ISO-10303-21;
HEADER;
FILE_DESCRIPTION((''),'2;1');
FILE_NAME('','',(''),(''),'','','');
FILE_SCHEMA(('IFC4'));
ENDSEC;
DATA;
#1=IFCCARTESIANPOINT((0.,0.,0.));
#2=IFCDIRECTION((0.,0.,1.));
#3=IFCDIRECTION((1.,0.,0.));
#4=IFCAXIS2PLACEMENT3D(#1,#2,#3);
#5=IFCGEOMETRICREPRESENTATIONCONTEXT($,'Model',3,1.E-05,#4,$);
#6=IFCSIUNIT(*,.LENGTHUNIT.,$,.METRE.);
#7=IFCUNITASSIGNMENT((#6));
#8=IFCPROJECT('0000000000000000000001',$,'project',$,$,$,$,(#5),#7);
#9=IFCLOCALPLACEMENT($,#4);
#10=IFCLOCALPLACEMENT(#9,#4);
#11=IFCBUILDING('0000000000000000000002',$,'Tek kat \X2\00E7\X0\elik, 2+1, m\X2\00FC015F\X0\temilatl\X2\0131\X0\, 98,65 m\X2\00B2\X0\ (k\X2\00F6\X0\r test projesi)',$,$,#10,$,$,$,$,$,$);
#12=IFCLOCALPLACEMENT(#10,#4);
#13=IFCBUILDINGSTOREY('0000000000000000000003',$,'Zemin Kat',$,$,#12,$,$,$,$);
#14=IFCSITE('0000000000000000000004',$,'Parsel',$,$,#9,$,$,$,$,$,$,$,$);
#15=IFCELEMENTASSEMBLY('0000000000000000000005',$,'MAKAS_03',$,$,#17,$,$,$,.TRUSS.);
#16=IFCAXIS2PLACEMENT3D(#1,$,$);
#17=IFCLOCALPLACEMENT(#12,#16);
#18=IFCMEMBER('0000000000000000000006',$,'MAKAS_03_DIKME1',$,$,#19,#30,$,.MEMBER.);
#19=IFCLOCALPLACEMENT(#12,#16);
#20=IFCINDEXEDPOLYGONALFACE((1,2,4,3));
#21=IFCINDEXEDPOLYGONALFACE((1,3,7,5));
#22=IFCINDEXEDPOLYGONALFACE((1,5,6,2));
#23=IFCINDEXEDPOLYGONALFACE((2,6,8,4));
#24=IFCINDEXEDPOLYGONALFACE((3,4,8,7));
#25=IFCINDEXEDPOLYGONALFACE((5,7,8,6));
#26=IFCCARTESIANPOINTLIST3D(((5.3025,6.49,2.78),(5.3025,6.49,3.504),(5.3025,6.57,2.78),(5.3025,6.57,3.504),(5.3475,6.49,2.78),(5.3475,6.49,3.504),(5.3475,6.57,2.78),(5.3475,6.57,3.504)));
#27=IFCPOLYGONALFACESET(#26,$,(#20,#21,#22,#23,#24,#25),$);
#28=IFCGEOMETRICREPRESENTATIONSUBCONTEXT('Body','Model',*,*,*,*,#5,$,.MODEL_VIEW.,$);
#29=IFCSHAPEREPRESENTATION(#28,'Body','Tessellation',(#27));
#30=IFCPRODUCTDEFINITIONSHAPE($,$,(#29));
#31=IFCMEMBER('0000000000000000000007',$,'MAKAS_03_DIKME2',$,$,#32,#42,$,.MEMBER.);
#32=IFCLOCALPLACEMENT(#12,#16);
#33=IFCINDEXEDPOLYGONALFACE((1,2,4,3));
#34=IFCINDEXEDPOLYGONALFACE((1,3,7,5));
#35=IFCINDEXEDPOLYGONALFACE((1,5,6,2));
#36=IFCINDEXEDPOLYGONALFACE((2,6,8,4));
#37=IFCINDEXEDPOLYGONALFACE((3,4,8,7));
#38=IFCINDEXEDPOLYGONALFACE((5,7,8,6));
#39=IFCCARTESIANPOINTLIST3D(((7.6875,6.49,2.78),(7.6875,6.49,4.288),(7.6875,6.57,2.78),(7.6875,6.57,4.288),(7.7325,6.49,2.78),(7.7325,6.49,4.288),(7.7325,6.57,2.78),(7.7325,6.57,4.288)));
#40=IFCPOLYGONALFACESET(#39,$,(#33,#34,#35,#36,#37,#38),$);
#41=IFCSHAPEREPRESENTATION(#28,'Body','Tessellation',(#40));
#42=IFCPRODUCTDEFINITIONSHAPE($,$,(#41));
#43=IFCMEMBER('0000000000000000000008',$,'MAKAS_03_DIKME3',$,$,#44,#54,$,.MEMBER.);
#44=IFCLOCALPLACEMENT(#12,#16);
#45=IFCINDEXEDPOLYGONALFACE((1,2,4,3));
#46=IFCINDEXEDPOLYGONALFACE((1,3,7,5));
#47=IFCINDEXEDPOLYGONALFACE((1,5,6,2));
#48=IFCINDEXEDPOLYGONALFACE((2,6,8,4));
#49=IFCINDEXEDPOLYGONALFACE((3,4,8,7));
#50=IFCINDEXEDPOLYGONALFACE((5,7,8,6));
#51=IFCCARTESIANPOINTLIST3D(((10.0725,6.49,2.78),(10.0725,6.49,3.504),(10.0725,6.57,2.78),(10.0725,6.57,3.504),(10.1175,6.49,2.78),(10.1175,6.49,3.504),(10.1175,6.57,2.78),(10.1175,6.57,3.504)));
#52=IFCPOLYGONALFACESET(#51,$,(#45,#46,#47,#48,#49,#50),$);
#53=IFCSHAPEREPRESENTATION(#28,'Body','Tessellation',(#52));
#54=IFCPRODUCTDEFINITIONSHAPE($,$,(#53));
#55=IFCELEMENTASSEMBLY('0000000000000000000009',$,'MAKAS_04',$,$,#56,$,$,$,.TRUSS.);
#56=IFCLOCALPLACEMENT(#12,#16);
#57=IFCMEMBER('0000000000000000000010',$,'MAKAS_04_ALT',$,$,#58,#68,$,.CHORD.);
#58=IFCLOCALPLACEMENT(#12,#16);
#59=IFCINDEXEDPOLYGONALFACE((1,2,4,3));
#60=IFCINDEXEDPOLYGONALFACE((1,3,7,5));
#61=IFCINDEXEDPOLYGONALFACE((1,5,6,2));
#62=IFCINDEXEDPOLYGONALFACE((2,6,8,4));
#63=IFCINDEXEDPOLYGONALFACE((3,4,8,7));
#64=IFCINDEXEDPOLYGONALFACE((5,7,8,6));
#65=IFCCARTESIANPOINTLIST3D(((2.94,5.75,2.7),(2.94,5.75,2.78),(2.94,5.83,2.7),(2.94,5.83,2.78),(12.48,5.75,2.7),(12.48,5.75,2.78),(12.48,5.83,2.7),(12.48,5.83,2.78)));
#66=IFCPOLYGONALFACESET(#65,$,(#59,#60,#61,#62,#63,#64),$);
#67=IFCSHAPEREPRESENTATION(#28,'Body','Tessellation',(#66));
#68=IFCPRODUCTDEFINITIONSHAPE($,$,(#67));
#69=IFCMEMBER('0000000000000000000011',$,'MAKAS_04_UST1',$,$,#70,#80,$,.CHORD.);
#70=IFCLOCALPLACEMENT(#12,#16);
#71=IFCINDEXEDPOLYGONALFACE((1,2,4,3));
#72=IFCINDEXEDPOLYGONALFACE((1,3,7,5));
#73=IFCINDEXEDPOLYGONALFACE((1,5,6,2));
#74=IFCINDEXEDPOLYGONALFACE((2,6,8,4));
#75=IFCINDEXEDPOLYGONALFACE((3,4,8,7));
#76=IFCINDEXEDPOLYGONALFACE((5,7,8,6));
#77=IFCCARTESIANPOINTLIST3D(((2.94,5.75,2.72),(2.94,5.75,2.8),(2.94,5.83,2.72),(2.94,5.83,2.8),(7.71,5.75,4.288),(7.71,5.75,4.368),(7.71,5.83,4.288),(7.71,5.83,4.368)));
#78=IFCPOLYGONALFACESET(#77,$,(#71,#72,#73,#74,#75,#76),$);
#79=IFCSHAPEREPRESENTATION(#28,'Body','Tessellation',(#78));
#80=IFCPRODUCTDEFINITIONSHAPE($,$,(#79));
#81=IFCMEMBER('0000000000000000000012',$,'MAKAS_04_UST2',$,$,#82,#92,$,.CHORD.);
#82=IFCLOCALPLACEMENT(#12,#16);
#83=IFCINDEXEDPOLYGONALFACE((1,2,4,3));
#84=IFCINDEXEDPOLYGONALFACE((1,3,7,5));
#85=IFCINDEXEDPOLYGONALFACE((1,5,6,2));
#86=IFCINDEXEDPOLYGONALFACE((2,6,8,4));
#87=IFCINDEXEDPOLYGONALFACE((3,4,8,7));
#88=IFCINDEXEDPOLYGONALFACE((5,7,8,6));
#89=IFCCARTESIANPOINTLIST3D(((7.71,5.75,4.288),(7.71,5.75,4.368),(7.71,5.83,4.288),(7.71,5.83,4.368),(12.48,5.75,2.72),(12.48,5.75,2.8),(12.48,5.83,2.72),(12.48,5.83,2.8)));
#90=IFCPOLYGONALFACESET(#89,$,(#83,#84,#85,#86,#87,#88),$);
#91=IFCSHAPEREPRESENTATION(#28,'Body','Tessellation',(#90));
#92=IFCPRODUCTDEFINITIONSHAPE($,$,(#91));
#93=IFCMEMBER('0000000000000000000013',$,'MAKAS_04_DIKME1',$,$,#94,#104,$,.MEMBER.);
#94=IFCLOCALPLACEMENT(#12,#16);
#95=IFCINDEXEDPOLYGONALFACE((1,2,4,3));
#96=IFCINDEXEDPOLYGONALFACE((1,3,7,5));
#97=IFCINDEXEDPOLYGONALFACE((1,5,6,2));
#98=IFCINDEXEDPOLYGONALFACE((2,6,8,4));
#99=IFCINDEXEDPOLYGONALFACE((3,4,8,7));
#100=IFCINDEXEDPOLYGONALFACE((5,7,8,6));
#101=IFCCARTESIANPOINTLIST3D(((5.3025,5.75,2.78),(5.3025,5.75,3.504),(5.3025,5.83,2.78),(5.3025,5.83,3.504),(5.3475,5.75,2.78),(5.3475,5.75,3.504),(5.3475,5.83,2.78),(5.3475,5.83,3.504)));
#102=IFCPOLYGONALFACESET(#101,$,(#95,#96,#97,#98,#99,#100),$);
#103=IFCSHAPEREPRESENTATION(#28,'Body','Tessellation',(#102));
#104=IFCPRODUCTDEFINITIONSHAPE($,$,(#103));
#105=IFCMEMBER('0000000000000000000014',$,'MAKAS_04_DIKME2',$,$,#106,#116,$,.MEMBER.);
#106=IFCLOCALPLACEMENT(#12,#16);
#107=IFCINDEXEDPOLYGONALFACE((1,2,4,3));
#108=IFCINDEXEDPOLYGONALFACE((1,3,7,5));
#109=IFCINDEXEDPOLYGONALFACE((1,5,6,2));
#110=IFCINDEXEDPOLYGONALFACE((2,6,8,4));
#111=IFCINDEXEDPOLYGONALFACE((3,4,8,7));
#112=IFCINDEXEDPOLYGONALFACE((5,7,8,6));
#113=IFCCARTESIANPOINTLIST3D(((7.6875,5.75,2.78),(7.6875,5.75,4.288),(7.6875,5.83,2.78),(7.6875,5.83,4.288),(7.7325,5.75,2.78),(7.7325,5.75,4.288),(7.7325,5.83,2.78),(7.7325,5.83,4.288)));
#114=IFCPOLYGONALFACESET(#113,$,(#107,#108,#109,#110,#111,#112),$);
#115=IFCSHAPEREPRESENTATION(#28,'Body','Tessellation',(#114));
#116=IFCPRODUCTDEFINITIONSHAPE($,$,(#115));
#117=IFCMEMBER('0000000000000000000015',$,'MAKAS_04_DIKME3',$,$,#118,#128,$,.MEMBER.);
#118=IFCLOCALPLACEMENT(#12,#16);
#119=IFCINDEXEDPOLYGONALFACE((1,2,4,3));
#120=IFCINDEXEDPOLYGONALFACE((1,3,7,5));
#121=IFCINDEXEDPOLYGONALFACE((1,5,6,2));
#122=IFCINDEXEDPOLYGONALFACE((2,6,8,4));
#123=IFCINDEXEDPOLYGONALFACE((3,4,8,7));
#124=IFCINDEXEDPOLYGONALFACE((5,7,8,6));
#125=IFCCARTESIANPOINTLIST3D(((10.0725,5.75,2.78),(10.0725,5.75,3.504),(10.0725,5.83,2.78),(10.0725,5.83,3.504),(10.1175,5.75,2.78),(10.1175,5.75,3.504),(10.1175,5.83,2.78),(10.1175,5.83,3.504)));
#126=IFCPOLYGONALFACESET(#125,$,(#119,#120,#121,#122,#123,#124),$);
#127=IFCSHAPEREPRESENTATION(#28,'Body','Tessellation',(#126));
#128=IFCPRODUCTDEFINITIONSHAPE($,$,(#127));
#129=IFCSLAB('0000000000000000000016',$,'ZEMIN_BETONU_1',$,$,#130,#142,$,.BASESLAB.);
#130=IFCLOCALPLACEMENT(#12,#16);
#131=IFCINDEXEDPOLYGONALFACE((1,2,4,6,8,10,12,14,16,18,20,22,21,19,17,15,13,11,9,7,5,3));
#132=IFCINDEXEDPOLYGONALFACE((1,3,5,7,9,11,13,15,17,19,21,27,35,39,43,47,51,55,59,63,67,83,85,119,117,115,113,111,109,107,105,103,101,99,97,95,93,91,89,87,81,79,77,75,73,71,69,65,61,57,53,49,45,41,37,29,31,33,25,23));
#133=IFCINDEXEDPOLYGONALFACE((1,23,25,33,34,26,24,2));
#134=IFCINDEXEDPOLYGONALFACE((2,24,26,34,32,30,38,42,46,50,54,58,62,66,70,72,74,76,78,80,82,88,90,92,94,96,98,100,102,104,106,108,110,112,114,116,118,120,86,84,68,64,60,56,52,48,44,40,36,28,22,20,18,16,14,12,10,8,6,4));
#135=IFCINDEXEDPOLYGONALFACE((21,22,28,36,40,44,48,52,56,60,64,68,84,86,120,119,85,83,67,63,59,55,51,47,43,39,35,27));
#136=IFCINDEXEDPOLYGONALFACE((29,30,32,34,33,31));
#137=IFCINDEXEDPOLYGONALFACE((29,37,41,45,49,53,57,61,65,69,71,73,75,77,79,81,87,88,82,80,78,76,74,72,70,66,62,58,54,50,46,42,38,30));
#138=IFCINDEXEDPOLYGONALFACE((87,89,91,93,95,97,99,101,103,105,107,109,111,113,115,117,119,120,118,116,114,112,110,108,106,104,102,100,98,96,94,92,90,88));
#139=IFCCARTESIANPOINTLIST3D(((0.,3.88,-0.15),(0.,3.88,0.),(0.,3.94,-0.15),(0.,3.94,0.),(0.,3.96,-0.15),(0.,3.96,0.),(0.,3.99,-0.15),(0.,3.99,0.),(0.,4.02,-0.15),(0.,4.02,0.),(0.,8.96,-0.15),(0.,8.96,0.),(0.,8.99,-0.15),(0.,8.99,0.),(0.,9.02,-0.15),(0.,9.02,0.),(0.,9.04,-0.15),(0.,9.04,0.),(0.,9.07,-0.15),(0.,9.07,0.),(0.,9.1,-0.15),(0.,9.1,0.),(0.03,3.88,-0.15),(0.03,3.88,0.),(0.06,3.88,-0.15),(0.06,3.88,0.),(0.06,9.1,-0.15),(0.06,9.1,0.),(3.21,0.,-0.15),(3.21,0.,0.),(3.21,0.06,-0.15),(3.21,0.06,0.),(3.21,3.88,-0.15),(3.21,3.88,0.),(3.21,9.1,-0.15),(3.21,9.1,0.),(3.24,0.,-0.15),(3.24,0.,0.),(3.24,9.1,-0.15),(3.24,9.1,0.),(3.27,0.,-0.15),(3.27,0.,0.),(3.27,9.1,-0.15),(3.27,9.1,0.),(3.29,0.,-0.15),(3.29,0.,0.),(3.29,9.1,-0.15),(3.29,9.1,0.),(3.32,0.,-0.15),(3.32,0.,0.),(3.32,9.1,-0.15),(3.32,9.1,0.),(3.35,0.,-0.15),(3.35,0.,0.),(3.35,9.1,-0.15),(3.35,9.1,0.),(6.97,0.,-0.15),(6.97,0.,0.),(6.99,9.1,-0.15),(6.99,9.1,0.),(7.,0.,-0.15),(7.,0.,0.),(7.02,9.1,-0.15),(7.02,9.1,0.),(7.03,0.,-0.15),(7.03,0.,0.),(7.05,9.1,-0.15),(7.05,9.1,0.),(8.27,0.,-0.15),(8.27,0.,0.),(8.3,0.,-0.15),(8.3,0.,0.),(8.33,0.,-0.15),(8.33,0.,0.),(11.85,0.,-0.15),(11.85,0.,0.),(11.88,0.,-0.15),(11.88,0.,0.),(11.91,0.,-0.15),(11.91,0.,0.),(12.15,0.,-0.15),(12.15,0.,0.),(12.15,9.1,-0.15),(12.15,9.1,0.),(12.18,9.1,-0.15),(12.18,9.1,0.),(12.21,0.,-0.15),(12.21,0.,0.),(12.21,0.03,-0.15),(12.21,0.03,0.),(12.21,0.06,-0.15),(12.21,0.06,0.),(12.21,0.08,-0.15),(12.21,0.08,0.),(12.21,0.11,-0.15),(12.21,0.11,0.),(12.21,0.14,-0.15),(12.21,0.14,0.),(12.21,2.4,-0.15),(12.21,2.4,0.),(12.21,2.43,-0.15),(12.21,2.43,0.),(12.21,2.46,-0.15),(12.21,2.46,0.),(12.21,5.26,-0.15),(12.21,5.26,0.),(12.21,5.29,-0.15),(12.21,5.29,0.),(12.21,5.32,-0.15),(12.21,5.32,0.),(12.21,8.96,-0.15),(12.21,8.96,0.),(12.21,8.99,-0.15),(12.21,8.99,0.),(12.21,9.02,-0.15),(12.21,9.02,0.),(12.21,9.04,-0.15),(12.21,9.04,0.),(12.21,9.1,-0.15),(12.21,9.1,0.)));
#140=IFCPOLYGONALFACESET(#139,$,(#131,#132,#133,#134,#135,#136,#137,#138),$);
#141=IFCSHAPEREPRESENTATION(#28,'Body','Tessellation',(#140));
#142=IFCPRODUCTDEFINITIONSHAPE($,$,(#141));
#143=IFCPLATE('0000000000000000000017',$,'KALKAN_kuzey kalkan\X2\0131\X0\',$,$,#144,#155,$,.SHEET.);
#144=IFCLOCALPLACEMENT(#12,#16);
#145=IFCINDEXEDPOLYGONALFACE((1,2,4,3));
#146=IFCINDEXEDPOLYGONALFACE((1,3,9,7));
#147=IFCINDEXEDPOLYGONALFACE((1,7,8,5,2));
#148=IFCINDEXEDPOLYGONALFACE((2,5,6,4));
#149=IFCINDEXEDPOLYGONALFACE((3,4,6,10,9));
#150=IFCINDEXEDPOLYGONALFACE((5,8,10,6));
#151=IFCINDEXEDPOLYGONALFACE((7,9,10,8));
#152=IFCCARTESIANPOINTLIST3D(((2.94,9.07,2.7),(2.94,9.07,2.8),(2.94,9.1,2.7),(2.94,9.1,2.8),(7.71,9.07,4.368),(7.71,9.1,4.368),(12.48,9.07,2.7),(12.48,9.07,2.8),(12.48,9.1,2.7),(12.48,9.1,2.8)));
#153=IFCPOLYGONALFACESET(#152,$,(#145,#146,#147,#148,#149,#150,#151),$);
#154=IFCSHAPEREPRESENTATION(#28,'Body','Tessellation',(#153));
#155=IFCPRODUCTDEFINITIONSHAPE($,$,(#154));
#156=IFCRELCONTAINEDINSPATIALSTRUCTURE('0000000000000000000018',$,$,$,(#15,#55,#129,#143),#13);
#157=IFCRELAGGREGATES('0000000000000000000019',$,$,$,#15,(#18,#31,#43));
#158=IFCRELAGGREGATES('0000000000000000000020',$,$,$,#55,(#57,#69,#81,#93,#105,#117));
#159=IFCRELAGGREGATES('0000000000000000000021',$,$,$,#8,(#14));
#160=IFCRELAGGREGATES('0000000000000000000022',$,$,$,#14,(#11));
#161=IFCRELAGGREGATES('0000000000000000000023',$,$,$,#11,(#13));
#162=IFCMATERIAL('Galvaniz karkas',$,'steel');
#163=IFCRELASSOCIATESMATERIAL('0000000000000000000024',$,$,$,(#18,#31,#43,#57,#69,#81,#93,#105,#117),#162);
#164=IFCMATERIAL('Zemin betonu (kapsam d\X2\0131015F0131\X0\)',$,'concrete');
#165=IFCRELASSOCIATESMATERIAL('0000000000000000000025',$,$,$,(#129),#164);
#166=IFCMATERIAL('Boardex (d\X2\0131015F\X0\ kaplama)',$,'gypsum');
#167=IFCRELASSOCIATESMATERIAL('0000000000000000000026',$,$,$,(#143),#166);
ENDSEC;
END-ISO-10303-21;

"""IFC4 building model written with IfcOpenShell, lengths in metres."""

from ifc_helpers import new_model, si_unit, frame, origin_with_axes, place, context, subcontext, project, spatial, line, indexed_curve, outline, extrude, material, element, aggregate, save


model = new_model("IFC4")

# Units and contexts
model_context = context("Model", 3, precision=1e-05, world=origin_with_axes())
body_context = subcontext(model_context, "Body", "Model", "MODEL_VIEW")
ifc_project = project(units=[si_unit("LENGTHUNIT", "METRE")], contexts=[model_context])

# Site, building, storey
site_placement = place(None, origin_with_axes())
site = spatial("IfcSite", under=ifc_project, at=site_placement, Name="Parsel")
building_placement = place(site_placement, origin_with_axes())
building = spatial("IfcBuilding", under=site, at=building_placement, Name="Tek kat çelik, 2+1, müştemilatlı, 98,65 m² (kör test projesi)")
storey_placement = place(building_placement, origin_with_axes())
storey = spatial("IfcBuildingStorey", under=building, at=storey_placement, Name="Zemin Kat")

# Element assemblies, members
ifc_material_1 = material(Name="Galvaniz karkas", Category="steel")
assembly_1_placement = place(storey_placement, origin_with_axes())
assembly_1 = element("IfcElementAssembly", 1, at=assembly_1_placement, inside=storey, Name="MAKAS_03", PredefinedType="TRUSS")
member_1_placement = place(assembly_1_placement, origin_with_axes())
member_1 = element("IfcMember", 2, at=member_1_placement, material=ifc_material_1, Name="MAKAS_03_DIKME1", PredefinedType="MEMBER", context=body_context, shape_type="SweptSolid", body=[
    extrude(outline(indexed_curve([(5.3025, 2.78), (5.3475, 2.78), (5.3475, 3.504), (5.3025, 3.504)], segments=[line(1, 2, 3, 4, 1)])), frame((0.0, 6.57, 0.0), z_axis=(0.0, -1.0, 0.0), x_axis=(1.0, 0.0, 0.0)), (0.0, 0.0, 1.0), 0.08),
])
member_2_placement = place(assembly_1_placement, origin_with_axes())
member_2 = element("IfcMember", 3, at=member_2_placement, material=ifc_material_1, Name="MAKAS_03_DIKME2", PredefinedType="MEMBER", context=body_context, shape_type="SweptSolid", body=[
    extrude(outline(indexed_curve([(7.6875, 2.78), (7.7325, 2.78), (7.7325, 4.288), (7.6875, 4.288)], segments=[line(1, 2, 3, 4, 1)])), frame((0.0, 6.57, 0.0), z_axis=(0.0, -1.0, 0.0), x_axis=(1.0, 0.0, 0.0)), (0.0, 0.0, 1.0), 0.08),
])
member_3_placement = place(assembly_1_placement, origin_with_axes())
member_3 = element("IfcMember", 4, at=member_3_placement, material=ifc_material_1, Name="MAKAS_03_DIKME3", PredefinedType="MEMBER", context=body_context, shape_type="SweptSolid", body=[
    extrude(outline(indexed_curve([(10.0725, 2.78), (10.1175, 2.78), (10.1175, 3.504), (10.0725, 3.504)], segments=[line(1, 2, 3, 4, 1)])), frame((0.0, 6.57, 0.0), z_axis=(0.0, -1.0, 0.0), x_axis=(1.0, 0.0, 0.0)), (0.0, 0.0, 1.0), 0.08),
])
aggregate(assembly_1, [member_1, member_2, member_3])
assembly_2_placement = place(storey_placement, origin_with_axes())
assembly_2 = element("IfcElementAssembly", 5, at=assembly_2_placement, inside=storey, Name="MAKAS_04", PredefinedType="TRUSS")
member_4_placement = place(assembly_2_placement, origin_with_axes())
member_4 = element("IfcMember", 6, at=member_4_placement, material=ifc_material_1, Name="MAKAS_04_ALT", PredefinedType="CHORD", context=body_context, shape_type="SweptSolid", body=[
    extrude(outline(indexed_curve([(2.94, 2.7), (12.48, 2.7), (12.48, 2.78), (2.94, 2.78)], segments=[line(1, 2, 3, 4, 1)])), frame((0.0, 5.83, 0.0), z_axis=(0.0, -1.0, 0.0), x_axis=(1.0, 0.0, 0.0)), (0.0, 0.0, 1.0), 0.08),
])
member_5_placement = place(assembly_2_placement, origin_with_axes())
member_5 = element("IfcMember", 7, at=member_5_placement, material=ifc_material_1, Name="MAKAS_04_UST1", PredefinedType="CHORD", context=body_context, shape_type="SweptSolid", body=[
    extrude(outline(indexed_curve([(2.94, 2.72), (7.71, 4.288), (7.71, 4.368), (2.94, 2.8)], segments=[line(1, 2, 3, 4, 1)])), frame((0.0, 5.83, 0.0), z_axis=(0.0, -1.0, 0.0), x_axis=(1.0, 0.0, 0.0)), (0.0, 0.0, 1.0), 0.08),
])
member_6_placement = place(assembly_2_placement, origin_with_axes())
member_6 = element("IfcMember", 8, at=member_6_placement, material=ifc_material_1, Name="MAKAS_04_UST2", PredefinedType="CHORD", context=body_context, shape_type="SweptSolid", body=[
    extrude(outline(indexed_curve([(7.71, 4.288), (12.48, 2.72), (12.48, 2.8), (7.71, 4.368)], segments=[line(1, 2, 3, 4, 1)])), frame((0.0, 5.83, 0.0), z_axis=(0.0, -1.0, 0.0), x_axis=(1.0, 0.0, 0.0)), (0.0, 0.0, 1.0), 0.08),
])
member_7_placement = place(assembly_2_placement, origin_with_axes())
member_7 = element("IfcMember", 9, at=member_7_placement, material=ifc_material_1, Name="MAKAS_04_DIKME1", PredefinedType="MEMBER", context=body_context, shape_type="SweptSolid", body=[
    extrude(outline(indexed_curve([(5.3025, 2.78), (5.3475, 2.78), (5.3475, 3.504), (5.3025, 3.504)], segments=[line(1, 2, 3, 4, 1)])), frame((0.0, 5.83, 0.0), z_axis=(0.0, -1.0, 0.0), x_axis=(1.0, 0.0, 0.0)), (0.0, 0.0, 1.0), 0.08),
])
member_8_placement = place(assembly_2_placement, origin_with_axes())
member_8 = element("IfcMember", 10, at=member_8_placement, material=ifc_material_1, Name="MAKAS_04_DIKME2", PredefinedType="MEMBER", context=body_context, shape_type="SweptSolid", body=[
    extrude(outline(indexed_curve([(7.6875, 2.78), (7.7325, 2.78), (7.7325, 4.288), (7.6875, 4.288)], segments=[line(1, 2, 3, 4, 1)])), frame((0.0, 5.83, 0.0), z_axis=(0.0, -1.0, 0.0), x_axis=(1.0, 0.0, 0.0)), (0.0, 0.0, 1.0), 0.08),
])
member_9_placement = place(assembly_2_placement, origin_with_axes())
member_9 = element("IfcMember", 11, at=member_9_placement, material=ifc_material_1, Name="MAKAS_04_DIKME3", PredefinedType="MEMBER", context=body_context, shape_type="SweptSolid", body=[
    extrude(outline(indexed_curve([(10.0725, 2.78), (10.1175, 2.78), (10.1175, 3.504), (10.0725, 3.504)], segments=[line(1, 2, 3, 4, 1)])), frame((0.0, 5.83, 0.0), z_axis=(0.0, -1.0, 0.0), x_axis=(1.0, 0.0, 0.0)), (0.0, 0.0, 1.0), 0.08),
])
aggregate(assembly_2, [member_4, member_5, member_6, member_7, member_8, member_9])

# Slab
ifc_material_2 = material(Name="Zemin betonu (kapsam dışı)", Category="concrete")
slab_placement = place(storey_placement, origin_with_axes())
element("IfcSlab", 12, at=slab_placement, inside=storey, material=ifc_material_2, Name="ZEMIN_BETONU_1", PredefinedType="BASESLAB", context=body_context, shape_type="SweptSolid", body=[
    extrude(outline(indexed_curve([(3.21, 0.0), (3.24, 0.0), (3.27, 0.0), (3.29, 0.0), (3.32, 0.0), (3.35, 0.0), (6.97, 0.0), (7.0, 0.0), (7.03, 0.0), (8.27, 0.0), (8.3, 0.0), (8.33, 0.0), (11.85, 0.0), (11.88, 0.0), (11.91, 0.0), (12.15, 0.0), (12.21, 0.0), (12.21, 0.03), (12.21, 0.06), (12.21, 0.08), (12.21, 0.11), (12.21, 0.14), (12.21, 2.4), (12.21, 2.43), (12.21, 2.46), (12.21, 5.26), (12.21, 5.29), (12.21, 5.32), (12.21, 8.96), (12.21, 8.99), (12.21, 9.02), (12.21, 9.04), (12.21, 9.1), (12.18, 9.1), (12.15, 9.1), (7.05, 9.1), (7.02, 9.1), (6.99, 9.1), (3.35, 9.1), (3.32, 9.1), (3.29, 9.1), (3.27, 9.1), (3.24, 9.1), (3.21, 9.1), (0.06, 9.1), (0.0, 9.1), (0.0, 9.07), (0.0, 9.04), (0.0, 9.02), (0.0, 8.99), (0.0, 8.96), (0.0, 4.02), (0.0, 3.99), (0.0, 3.96), (0.0, 3.94), (0.0, 3.88), (0.03, 3.88), (0.06, 3.88), (3.21, 3.88), (3.21, 0.06)], segments=[line(1, 2, 3, 4, 5, 6, 7, 8, 9, 10, 11, 12, 13, 14, 15, 16, 17, 18, 19, 20, 21, 22, 23, 24, 25, 26, 27, 28, 29, 30, 31, 32, 33, 34, 35, 36, 37, 38, 39, 40, 41, 42, 43, 44, 45, 46, 47, 48, 49, 50, 51, 52, 53, 54, 55, 56, 57, 58, 59, 60, 1)])), frame((0.0, 0.0, -0.15), z_axis=(0.0, 0.0, 1.0), x_axis=(1.0, 0.0, 0.0)), (0.0, 0.0, 1.0), 0.15),
])

# Plate
ifc_material_3 = material(Name="Boardex (dış kaplama)", Category="gypsum")
plate_1_placement = place(storey_placement, origin_with_axes())
element("IfcPlate", 13, at=plate_1_placement, inside=storey, material=ifc_material_3, Name="KALKAN_kuzey kalkanı", PredefinedType="SHEET", context=body_context, shape_type="SweptSolid", body=[
    extrude(outline(indexed_curve([(2.94, 2.8), (7.71, 4.368), (12.48, 2.8), (12.48, 2.7), (2.94, 2.7)], segments=[line(1, 2, 3, 4, 5, 1)])), frame((0.0, 9.1, 0.0), z_axis=(0.0, -1.0, 0.0), x_axis=(1.0, 0.0, 0.0)), (0.0, 0.0, 1.0), 0.03),
])

save(model, "model.ifc")
